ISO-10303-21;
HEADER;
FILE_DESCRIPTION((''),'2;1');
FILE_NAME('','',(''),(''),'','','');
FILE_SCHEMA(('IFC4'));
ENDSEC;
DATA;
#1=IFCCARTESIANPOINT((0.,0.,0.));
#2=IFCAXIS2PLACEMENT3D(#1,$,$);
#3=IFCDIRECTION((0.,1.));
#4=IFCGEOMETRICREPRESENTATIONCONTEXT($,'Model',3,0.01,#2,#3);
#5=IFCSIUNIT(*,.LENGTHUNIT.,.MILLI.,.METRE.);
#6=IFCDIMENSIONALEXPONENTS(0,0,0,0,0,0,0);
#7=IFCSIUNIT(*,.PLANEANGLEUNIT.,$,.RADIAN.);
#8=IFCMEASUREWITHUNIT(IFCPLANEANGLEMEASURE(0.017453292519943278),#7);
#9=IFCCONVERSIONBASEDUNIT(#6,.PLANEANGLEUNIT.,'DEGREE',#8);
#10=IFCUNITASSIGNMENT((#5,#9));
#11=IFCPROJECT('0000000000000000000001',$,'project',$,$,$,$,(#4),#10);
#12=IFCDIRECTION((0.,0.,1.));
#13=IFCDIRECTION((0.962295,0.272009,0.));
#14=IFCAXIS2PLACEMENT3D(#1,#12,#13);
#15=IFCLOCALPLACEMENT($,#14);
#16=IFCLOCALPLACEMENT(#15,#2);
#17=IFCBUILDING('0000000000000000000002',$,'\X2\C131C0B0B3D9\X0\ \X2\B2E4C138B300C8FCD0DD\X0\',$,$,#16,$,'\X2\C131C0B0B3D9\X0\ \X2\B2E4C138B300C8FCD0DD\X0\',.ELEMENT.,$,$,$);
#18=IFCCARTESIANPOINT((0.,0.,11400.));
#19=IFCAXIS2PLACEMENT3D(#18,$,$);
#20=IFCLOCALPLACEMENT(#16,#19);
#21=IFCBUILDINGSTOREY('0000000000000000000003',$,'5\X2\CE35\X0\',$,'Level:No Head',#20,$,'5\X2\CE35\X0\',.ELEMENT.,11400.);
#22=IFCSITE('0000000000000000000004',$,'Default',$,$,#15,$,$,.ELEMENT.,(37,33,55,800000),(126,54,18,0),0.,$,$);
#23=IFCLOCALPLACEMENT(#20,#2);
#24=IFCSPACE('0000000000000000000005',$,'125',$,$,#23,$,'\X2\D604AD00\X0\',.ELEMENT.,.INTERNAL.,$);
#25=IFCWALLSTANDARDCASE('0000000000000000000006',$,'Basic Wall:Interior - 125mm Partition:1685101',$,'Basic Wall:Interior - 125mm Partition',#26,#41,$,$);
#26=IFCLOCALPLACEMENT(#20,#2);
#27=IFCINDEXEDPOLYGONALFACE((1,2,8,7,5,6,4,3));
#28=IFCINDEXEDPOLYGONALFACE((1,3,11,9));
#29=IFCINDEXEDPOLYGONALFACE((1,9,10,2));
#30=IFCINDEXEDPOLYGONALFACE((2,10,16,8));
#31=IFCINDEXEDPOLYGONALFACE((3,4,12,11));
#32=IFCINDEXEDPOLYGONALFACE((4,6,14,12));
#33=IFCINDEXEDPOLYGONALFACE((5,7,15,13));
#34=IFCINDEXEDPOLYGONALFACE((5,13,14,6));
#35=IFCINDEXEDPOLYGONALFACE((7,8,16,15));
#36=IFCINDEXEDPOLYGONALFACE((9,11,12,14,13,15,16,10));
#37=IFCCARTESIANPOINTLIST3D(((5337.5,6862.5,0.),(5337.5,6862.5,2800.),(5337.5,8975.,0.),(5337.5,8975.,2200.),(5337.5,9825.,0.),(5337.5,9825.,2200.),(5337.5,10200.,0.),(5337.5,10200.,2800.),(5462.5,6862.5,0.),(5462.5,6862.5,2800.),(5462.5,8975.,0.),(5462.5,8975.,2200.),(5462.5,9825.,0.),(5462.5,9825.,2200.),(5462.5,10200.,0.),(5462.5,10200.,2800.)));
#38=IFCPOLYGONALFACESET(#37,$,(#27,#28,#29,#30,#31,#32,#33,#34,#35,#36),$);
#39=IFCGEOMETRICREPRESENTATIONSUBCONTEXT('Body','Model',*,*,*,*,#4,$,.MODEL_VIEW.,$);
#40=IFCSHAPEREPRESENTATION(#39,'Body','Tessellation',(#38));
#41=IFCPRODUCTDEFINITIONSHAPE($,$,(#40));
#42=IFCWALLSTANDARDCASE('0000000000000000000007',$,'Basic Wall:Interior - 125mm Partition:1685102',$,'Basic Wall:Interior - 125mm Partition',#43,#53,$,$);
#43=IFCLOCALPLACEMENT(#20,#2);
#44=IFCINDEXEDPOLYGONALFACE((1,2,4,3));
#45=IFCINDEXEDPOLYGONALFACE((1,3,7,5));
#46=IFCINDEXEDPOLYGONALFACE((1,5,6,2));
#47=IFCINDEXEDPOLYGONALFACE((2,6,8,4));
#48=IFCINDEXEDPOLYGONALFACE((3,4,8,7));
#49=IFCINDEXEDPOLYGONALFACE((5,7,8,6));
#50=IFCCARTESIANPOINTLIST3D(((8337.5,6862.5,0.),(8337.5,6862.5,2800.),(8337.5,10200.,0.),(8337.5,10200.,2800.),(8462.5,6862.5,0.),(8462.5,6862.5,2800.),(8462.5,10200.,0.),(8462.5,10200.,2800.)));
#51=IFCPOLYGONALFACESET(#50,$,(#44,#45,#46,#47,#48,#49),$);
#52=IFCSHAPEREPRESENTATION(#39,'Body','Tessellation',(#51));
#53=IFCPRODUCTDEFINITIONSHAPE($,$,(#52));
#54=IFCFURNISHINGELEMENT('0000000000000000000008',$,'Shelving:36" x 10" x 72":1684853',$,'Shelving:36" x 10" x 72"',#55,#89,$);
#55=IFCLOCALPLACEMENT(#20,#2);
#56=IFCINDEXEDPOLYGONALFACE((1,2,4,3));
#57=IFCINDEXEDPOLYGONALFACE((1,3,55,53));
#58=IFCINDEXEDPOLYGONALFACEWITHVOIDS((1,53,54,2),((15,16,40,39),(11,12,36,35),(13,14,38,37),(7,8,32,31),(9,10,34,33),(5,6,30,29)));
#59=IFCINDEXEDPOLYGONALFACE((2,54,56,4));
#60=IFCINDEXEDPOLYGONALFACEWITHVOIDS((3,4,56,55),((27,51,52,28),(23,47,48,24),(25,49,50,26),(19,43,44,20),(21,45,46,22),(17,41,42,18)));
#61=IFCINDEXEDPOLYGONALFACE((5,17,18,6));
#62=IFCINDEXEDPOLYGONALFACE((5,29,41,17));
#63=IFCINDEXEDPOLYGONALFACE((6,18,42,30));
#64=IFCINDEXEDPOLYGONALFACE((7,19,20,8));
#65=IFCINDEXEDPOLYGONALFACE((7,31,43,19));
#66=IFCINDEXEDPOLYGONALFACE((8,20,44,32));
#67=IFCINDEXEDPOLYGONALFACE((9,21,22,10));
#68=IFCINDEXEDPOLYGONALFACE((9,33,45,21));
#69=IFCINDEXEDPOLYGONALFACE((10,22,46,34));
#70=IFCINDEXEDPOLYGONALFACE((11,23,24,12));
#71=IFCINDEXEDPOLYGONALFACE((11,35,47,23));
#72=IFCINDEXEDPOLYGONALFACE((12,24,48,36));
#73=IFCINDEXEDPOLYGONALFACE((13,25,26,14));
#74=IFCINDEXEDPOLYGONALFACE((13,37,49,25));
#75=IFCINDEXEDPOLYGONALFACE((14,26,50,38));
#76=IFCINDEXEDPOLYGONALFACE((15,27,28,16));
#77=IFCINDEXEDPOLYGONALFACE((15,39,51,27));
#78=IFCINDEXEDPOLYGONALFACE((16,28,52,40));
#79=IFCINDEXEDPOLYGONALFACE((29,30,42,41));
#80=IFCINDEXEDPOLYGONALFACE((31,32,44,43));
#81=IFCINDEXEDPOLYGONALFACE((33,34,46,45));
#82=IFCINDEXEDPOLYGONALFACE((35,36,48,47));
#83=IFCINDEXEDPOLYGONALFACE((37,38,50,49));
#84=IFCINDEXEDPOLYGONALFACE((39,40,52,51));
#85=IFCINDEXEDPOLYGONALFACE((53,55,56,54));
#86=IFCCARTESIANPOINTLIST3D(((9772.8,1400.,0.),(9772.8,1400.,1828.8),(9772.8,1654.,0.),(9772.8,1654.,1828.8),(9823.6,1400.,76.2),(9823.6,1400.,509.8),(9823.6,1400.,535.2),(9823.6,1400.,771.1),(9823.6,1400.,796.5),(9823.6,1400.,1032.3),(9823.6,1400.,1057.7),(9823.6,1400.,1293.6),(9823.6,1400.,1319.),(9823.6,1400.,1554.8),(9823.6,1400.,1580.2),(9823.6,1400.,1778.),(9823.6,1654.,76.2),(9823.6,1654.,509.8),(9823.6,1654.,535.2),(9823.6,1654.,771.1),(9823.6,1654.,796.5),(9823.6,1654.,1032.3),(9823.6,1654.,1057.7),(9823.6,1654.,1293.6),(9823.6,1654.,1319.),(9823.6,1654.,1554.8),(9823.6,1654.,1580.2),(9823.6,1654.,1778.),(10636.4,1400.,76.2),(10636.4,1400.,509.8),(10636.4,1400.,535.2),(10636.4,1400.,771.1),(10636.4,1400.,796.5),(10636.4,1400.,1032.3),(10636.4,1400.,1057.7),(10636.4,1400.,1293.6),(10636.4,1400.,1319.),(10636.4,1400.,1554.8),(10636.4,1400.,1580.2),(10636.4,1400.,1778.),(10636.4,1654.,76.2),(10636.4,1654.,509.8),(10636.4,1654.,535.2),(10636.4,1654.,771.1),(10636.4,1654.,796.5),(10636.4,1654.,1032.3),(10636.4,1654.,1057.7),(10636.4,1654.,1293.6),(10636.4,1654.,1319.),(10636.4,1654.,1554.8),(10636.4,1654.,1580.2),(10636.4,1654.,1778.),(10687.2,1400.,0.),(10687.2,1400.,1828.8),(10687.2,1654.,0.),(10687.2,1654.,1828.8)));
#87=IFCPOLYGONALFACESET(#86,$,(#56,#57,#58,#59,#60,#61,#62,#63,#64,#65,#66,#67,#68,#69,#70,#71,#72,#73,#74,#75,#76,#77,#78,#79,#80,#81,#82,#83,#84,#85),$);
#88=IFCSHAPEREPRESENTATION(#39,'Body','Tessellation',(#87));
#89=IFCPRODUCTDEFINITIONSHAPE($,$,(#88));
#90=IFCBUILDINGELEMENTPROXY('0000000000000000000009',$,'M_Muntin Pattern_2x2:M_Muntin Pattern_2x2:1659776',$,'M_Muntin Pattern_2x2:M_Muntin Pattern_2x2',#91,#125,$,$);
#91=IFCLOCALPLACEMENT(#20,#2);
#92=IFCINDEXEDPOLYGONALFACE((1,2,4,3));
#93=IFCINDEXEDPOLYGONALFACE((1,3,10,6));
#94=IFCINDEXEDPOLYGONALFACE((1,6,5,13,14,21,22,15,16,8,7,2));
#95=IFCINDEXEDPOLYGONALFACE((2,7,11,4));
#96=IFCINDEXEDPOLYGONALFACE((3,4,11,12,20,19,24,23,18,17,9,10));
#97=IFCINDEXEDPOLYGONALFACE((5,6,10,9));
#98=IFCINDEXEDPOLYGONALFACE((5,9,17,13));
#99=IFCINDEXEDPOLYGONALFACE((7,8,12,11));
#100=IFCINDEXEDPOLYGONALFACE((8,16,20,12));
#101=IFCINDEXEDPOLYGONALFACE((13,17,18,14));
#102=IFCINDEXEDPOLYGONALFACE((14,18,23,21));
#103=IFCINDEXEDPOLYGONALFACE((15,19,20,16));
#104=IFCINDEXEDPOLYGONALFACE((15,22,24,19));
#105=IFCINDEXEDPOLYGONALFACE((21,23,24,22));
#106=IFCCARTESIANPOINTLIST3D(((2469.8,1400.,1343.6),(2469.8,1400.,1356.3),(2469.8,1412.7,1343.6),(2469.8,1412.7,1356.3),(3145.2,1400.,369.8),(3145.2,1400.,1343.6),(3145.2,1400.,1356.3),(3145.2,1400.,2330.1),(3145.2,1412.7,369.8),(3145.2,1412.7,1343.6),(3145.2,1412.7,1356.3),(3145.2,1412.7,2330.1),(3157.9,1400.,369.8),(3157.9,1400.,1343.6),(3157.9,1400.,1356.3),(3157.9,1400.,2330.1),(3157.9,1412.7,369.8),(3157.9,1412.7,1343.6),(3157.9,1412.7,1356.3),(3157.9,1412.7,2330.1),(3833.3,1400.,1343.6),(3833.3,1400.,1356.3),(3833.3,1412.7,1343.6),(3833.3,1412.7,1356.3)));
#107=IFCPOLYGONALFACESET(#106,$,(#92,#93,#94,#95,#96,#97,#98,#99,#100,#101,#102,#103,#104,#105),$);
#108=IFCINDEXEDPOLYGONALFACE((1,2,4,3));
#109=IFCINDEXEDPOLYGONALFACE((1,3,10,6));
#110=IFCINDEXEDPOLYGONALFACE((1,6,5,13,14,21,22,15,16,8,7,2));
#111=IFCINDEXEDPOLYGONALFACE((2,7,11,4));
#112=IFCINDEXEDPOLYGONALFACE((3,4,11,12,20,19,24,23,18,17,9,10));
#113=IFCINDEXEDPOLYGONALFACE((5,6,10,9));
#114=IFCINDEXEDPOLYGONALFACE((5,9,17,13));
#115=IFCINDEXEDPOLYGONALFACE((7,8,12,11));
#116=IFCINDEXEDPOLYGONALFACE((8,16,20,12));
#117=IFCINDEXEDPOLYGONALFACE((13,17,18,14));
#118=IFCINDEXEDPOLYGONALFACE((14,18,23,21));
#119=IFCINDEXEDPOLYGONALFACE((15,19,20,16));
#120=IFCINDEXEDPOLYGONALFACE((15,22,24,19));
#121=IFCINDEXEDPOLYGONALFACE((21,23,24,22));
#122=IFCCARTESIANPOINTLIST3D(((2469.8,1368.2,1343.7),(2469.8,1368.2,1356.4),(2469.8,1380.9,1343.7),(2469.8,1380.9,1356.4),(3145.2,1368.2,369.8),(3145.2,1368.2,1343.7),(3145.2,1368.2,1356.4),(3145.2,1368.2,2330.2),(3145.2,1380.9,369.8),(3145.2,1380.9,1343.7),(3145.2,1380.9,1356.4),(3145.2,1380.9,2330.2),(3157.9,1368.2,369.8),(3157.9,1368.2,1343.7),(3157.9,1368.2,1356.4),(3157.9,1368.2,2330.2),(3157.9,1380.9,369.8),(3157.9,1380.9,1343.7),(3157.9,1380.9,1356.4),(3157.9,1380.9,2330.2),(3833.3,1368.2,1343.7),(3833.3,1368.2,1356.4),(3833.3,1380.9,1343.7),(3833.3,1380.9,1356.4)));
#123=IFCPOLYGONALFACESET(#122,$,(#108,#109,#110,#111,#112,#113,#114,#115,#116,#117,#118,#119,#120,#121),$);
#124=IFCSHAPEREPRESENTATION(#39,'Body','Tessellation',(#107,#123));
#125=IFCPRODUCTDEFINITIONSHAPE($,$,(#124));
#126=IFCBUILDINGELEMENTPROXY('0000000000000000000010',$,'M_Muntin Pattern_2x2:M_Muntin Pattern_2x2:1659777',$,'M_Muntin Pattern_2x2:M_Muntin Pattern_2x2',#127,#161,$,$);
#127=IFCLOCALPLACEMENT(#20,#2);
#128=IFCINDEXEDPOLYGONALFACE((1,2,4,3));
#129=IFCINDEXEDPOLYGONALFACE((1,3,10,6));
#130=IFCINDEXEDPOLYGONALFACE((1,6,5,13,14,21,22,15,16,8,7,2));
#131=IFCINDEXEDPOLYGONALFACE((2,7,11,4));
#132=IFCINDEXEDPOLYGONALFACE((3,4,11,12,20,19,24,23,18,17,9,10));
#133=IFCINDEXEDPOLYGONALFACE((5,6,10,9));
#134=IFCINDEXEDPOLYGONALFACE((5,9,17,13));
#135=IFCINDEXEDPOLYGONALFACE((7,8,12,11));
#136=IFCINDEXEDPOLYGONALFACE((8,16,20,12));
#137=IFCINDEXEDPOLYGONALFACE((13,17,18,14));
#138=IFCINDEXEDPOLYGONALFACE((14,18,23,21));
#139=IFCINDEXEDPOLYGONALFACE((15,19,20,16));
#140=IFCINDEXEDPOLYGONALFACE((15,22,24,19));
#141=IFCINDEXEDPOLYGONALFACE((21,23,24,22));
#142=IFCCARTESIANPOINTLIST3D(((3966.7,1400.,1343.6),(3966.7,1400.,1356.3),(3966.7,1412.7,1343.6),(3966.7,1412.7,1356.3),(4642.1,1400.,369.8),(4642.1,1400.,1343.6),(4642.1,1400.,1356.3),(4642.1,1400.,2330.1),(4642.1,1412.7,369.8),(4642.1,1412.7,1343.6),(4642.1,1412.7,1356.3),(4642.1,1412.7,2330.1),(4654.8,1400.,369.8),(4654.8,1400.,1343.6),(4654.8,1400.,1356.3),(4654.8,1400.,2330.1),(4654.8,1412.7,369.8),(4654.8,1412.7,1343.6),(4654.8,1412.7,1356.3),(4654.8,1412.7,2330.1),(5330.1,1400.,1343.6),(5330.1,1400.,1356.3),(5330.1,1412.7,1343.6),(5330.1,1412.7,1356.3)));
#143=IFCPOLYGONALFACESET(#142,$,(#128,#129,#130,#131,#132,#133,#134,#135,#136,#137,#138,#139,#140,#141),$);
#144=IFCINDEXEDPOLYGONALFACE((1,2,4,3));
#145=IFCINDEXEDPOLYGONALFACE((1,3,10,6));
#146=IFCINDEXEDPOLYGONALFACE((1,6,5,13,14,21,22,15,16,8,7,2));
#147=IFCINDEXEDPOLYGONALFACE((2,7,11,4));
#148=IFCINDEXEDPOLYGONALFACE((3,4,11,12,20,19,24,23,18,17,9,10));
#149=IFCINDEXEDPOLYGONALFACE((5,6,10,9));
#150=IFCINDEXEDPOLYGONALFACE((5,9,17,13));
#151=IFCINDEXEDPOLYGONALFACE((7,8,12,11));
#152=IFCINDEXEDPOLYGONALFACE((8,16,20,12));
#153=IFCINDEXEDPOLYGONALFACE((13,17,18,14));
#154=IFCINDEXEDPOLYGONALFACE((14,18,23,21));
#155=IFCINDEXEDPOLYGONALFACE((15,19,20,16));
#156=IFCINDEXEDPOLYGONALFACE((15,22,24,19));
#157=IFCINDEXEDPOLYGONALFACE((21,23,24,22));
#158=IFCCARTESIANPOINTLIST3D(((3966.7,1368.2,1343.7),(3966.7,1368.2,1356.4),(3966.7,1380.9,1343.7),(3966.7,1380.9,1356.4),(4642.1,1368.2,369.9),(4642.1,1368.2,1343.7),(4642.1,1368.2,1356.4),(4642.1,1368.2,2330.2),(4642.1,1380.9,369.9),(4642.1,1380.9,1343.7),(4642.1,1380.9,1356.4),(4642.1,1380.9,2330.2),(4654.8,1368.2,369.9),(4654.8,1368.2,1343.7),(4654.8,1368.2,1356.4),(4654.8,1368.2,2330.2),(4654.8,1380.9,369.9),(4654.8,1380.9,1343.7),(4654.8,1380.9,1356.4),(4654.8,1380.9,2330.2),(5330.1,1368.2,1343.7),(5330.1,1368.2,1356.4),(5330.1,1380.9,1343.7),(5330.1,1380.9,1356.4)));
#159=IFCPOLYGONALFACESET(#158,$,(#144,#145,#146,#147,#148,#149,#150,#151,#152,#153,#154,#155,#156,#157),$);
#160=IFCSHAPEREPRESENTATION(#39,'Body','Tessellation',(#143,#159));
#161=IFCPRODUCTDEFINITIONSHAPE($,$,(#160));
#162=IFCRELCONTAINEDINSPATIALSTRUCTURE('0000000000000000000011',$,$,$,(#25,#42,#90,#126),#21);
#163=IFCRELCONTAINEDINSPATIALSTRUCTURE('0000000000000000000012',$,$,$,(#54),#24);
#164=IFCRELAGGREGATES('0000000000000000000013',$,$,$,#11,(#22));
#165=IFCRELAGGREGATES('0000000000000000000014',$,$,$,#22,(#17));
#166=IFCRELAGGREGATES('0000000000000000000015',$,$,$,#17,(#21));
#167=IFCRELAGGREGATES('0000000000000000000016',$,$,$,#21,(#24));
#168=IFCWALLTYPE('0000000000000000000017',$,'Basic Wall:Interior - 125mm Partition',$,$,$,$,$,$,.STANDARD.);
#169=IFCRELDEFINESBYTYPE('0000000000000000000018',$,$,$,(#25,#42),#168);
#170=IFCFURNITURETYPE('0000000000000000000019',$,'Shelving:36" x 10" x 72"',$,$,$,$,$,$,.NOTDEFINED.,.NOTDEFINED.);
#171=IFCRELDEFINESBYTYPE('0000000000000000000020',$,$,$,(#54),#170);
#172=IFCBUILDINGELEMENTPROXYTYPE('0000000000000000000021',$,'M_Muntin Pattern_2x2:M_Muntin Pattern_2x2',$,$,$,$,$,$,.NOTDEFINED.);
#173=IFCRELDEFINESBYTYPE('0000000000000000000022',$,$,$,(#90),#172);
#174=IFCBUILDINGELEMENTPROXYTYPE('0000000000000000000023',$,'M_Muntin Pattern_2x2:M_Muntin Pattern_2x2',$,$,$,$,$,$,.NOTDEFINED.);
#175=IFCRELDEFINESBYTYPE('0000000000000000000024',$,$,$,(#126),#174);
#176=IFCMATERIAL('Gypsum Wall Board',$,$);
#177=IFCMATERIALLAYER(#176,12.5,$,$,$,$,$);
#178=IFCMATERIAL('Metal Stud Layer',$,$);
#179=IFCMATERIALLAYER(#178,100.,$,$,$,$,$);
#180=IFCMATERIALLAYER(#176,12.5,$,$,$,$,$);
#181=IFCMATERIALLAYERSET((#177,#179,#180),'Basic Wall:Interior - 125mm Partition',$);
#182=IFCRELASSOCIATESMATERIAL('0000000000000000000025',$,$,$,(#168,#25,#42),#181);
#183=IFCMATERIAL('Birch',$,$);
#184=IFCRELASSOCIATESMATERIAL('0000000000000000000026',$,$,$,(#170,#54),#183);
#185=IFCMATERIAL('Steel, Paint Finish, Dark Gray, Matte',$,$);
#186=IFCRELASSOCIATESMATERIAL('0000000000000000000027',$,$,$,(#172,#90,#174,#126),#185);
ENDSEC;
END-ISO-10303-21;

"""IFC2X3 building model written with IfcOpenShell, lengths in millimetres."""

from ifc_helpers import new_model, entity, si_unit, converted_unit, direction, frame, frame_2d, origin, place, context, subcontext, project, spatial, polyline, rectangle, outline, extrude, source, transform, mapped, material, layer, layer_set, layer_usage, type_object, type_shapes, element, save


model = new_model("IFC2X3")

# Units and contexts
model_context = context("Model", 3, precision=0.01, world=origin(), true_north=direction((0.0, 1.0)))
body_context = subcontext(model_context, "Body", "Model", "MODEL_VIEW")
ifc_project = project(units=[si_unit("LENGTHUNIT", "METRE", prefix="MILLI"), converted_unit("PLANEANGLEUNIT", "DEGREE", entity("IfcPlaneAngleMeasure", 0.017453292519943278), si_unit("PLANEANGLEUNIT", "RADIAN"), dimensions=[0, 0, 0, 0, 0, 0, 0])], contexts=[model_context])

# Site, building, storey
site_placement = place(None, frame((0.0, 0.0, 0.0), z_axis=(0.0, 0.0, 1.0), x_axis=(0.962295, 0.272009, 0.0)))
site = spatial("IfcSite", under=ifc_project, at=site_placement, Name="Default", CompositionType="ELEMENT", RefLatitude=(37, 33, 55, 800000), RefLongitude=(126, 54, 18, 0), RefElevation=0.0)
building_placement = place(site_placement, origin())
building = spatial("IfcBuilding", under=site, at=building_placement, Name="성산동 다세대주택", LongName="성산동 다세대주택", CompositionType="ELEMENT")
storey_placement = place(building_placement, frame((0.0, 0.0, 11400.0)))
storey = spatial("IfcBuildingStorey", under=building, at=storey_placement, Name="5층", ObjectType="Level:No Head", LongName="5층", CompositionType="ELEMENT", Elevation=11400.0)

# Shared definitions
ifc_material_1 = material(Name="Steel, Paint Finish, Dark Gray, Matte")
ifc_material_2 = material(Name="Gypsum Wall Board")

# Shared definitions
ifc_layer_1 = layer(ifc_material_2, 12.5)
ifc_material_3 = material(Name="Metal Stud Layer")
ifc_layer_2 = layer(ifc_material_3, 100.0)
ifc_layer_3 = layer(ifc_material_2, 12.5)
ifc_layer_set_1 = layer_set([ifc_layer_1, ifc_layer_2, ifc_layer_3], Name="Basic Wall:Interior - 125mm Partition")
wall_type_1 = type_object("IfcWallType", Name="Basic Wall:Interior - 125mm Partition", PredefinedType="STANDARD", material=ifc_layer_set_1)

# Wall, opening
ifc_layer_usage_1 = layer_usage(ifc_layer_set_1, "AXIS2", "NEGATIVE", 62.5)
wall_1_placement = place(storey_placement, frame((5400.0, 6862.5, 0.0), z_axis=(0.0, 0.0, 1.0), x_axis=(0.0, 1.0, 0.0)))
wall_1 = element("IfcWallStandardCase", 1, at=wall_1_placement, inside=storey, type_object=wall_type_1, material=ifc_layer_usage_1, Name="Basic Wall:Interior - 125mm Partition:1685101", ObjectType="Basic Wall:Interior - 125mm Partition", context=body_context, shape_type="SweptSolid", body=[
    extrude(rectangle(XDim=3337.5, YDim=125.0, at=frame_2d((1668.7, 0.0), x_axis=(1.0, 0.0))), origin(), (0.0, 0.0, 1.0), 2800.0),
])
opening_1_placement = place(wall_1_placement, frame((2112.5, -62.5, 0.0)))
element("IfcOpeningElement", 2, at=opening_1_placement, cuts=wall_1, ObjectType="Opening", context=body_context, shape_type="SweptSolid", body=[
    extrude(rectangle(XDim=2200.0, YDim=850.0, at=frame_2d((1100.0, 425.0), x_axis=(1.0, 0.0))), frame((0.0, 0.0, 0.0), z_axis=(0.0, 1.0, 0.0), x_axis=(0.0, 0.0, 1.0)), (0.0, 0.0, 1.0), 125.0),
])

# Wall
ifc_layer_usage_2 = layer_usage(ifc_layer_set_1, "AXIS2", "NEGATIVE", 62.5)
wall_2_placement = place(storey_placement, frame((8400.0, 6862.5, 0.0), z_axis=(0.0, 0.0, 1.0), x_axis=(0.0, 1.0, 0.0)))
element("IfcWallStandardCase", 3, at=wall_2_placement, inside=storey, type_object=wall_type_1, material=ifc_layer_usage_2, Name="Basic Wall:Interior - 125mm Partition:1685102", ObjectType="Basic Wall:Interior - 125mm Partition", context=body_context, shape_type="SweptSolid", body=[
    extrude(rectangle(XDim=3337.5, YDim=125.0, at=frame_2d((1668.7, 0.0), x_axis=(-1.0, 0.0))), origin(), (0.0, 0.0, 1.0), 2800.0),
])

# Shared definitions
space_1_placement = place(storey_placement, origin())
space_1 = spatial("IfcSpace", under=storey, at=space_1_placement, Name="125", LongName="현관", CompositionType="ELEMENT", InteriorOrExteriorSpace="INTERNAL")

# Furnishing element
ifc_material_4 = material(Name="Birch")
furniture_type_1 = type_object("IfcFurnitureType", Name="Shelving:36\" x 10\" x 72\"", AssemblyPlace="NOTDEFINED", material=ifc_material_4)
shared_shape_1 = source(origin(), body_context, "Body", "SweptSolid", [
    extrude(outline(polyline([(-457.2, -914.4), (457.2, -914.4), (457.2, 914.4), (-457.2, 914.4), (-457.2, -914.4)]), holes=[polyline([(-406.4, 863.6), (406.4, 863.6), (406.4, 665.8), (-406.4, 665.8), (-406.4, 863.6)]), polyline([(-406.4, -838.2), (-406.4, -404.6), (406.4, -404.6), (406.4, -838.2), (-406.4, -838.2)]), polyline([(406.4, 143.3), (-406.4, 143.3), (-406.4, 379.2), (406.4, 379.2), (406.4, 143.3)]), polyline([(-406.4, 640.4), (406.4, 640.4), (406.4, 404.6), (-406.4, 404.6), (-406.4, 640.4)]), polyline([(-406.4, 117.9), (406.4, 117.9), (406.4, -117.9), (-406.4, -117.9), (-406.4, 117.9)]), polyline([(-406.4, -143.3), (406.4, -143.3), (406.4, -379.2), (-406.4, -379.2), (-406.4, -143.3)])]), frame((0.0, -431.8, 914.4), z_axis=(0.0, 1.0, 0.0), x_axis=(-1.0, 0.0, 0.0)), (0.0, 0.0, 1.0), 254.0),
])
type_shapes(furniture_type_1, [shared_shape_1])
furnishing_1_placement = place(space_1_placement, frame((10230.0, 1222.2, 0.0), z_axis=(0.0, 0.0, 1.0), x_axis=(-1.0, 0.0, 0.0)))
element("IfcFurnishingElement", 4, at=furnishing_1_placement, inside=space_1, type_object=furniture_type_1, material=ifc_material_4, Name="Shelving:36\" x 10\" x 72\":1684853", ObjectType="Shelving:36\" x 10\" x 72\"", context=body_context, shape_type="MappedRepresentation", body=[
    mapped(shared_shape_1, transform((0.0, 0.0, 0.0), scale=1.0)),
])

# Building element proxies
building_element_proxy_type_1 = type_object("IfcBuildingElementProxyType", Name="M_Muntin Pattern_2x2:M_Muntin Pattern_2x2", PredefinedType="NOTDEFINED", material=ifc_material_1)
shared_shape_2 = source(origin(), body_context, "Body", "SweptSolid", [
    extrude(outline(polyline([(6.4, -6.4), (980.1, -6.4), (980.1, 6.3), (6.4, 6.3), (6.4, 681.7), (-6.3, 681.7), (-6.3, 6.3), (-980.2, 6.3), (-980.2, -6.4), (-6.3, -6.4), (-6.3, -681.7), (6.4, -681.7), (6.4, -6.4)])), frame((0.0, 9.5, 980.1), z_axis=(0.0, 1.0, 0.0), x_axis=(0.0, 0.0, 1.0)), (0.0, 0.0, 1.0), 12.7),
    extrude(outline(polyline([(6.4, -6.4), (980.2, -6.4), (980.2, 6.3), (6.4, 6.3), (6.4, 681.7), (-6.3, 681.7), (-6.3, 6.3), (-980.2, 6.3), (-980.2, -6.4), (-6.3, -6.4), (-6.3, -681.7), (6.4, -681.7), (6.4, -6.4)])), frame((0.0, -22.2, 980.2), z_axis=(0.0, 1.0, 0.0), x_axis=(0.0, 0.0, 1.0)), (0.0, 0.0, 1.0), 12.7),
])
type_shapes(building_element_proxy_type_1, [shared_shape_2])
proxy_1_placement = place(storey_placement, frame((3151.6, 1390.5, 369.8)))
element("IfcBuildingElementProxy", 5, at=proxy_1_placement, inside=storey, type_object=building_element_proxy_type_1, material=ifc_material_1, Name="M_Muntin Pattern_2x2:M_Muntin Pattern_2x2:1659776", ObjectType="M_Muntin Pattern_2x2:M_Muntin Pattern_2x2", context=body_context, shape_type="MappedRepresentation", body=[
    mapped(shared_shape_2, transform((0.0, 0.0, 0.0), scale=1.0)),
])
building_element_proxy_type_2 = type_object("IfcBuildingElementProxyType", Name="M_Muntin Pattern_2x2:M_Muntin Pattern_2x2", PredefinedType="NOTDEFINED", material=ifc_material_1)
shared_shape_3 = source(origin(), body_context, "Body", "SweptSolid", [
    extrude(outline(polyline([(6.4, -6.4), (980.1, -6.4), (980.1, 6.3), (6.4, 6.3), (6.4, 681.7), (-6.3, 681.7), (-6.3, 6.3), (-980.2, 6.3), (-980.2, -6.4), (-6.3, -6.4), (-6.3, -681.7), (6.4, -681.7), (6.4, -6.4)])), frame((0.0, -22.2, 980.1), z_axis=(0.0, 1.0, 0.0), x_axis=(0.0, 0.0, 1.0)), (0.0, 0.0, 1.0), 12.7),
    extrude(outline(polyline([(6.4, -6.4), (980.2, -6.4), (980.2, 6.3), (6.4, 6.3), (6.4, 681.7), (-6.3, 681.7), (-6.3, 6.3), (-980.2, 6.3), (-980.2, -6.4), (-6.3, -6.4), (-6.3, -681.7), (6.4, -681.7), (6.4, -6.4)])), frame((0.0, 9.5, 980.2), z_axis=(0.0, 1.0, 0.0), x_axis=(0.0, 0.0, 1.0)), (0.0, 0.0, 1.0), 12.7),
])
type_shapes(building_element_proxy_type_2, [shared_shape_3])
proxy_2_placement = place(storey_placement, frame((4648.4, 1390.5, 369.9), z_axis=(0.0, 0.0, 1.0), x_axis=(-1.0, 0.0, 0.0)))
element("IfcBuildingElementProxy", 6, at=proxy_2_placement, inside=storey, type_object=building_element_proxy_type_2, material=ifc_material_1, Name="M_Muntin Pattern_2x2:M_Muntin Pattern_2x2:1659777", ObjectType="M_Muntin Pattern_2x2:M_Muntin Pattern_2x2", context=body_context, shape_type="MappedRepresentation", body=[
    mapped(shared_shape_3, transform((0.0, 0.0, 0.0), scale=1.0)),
])

save(model, "model.ifc")
